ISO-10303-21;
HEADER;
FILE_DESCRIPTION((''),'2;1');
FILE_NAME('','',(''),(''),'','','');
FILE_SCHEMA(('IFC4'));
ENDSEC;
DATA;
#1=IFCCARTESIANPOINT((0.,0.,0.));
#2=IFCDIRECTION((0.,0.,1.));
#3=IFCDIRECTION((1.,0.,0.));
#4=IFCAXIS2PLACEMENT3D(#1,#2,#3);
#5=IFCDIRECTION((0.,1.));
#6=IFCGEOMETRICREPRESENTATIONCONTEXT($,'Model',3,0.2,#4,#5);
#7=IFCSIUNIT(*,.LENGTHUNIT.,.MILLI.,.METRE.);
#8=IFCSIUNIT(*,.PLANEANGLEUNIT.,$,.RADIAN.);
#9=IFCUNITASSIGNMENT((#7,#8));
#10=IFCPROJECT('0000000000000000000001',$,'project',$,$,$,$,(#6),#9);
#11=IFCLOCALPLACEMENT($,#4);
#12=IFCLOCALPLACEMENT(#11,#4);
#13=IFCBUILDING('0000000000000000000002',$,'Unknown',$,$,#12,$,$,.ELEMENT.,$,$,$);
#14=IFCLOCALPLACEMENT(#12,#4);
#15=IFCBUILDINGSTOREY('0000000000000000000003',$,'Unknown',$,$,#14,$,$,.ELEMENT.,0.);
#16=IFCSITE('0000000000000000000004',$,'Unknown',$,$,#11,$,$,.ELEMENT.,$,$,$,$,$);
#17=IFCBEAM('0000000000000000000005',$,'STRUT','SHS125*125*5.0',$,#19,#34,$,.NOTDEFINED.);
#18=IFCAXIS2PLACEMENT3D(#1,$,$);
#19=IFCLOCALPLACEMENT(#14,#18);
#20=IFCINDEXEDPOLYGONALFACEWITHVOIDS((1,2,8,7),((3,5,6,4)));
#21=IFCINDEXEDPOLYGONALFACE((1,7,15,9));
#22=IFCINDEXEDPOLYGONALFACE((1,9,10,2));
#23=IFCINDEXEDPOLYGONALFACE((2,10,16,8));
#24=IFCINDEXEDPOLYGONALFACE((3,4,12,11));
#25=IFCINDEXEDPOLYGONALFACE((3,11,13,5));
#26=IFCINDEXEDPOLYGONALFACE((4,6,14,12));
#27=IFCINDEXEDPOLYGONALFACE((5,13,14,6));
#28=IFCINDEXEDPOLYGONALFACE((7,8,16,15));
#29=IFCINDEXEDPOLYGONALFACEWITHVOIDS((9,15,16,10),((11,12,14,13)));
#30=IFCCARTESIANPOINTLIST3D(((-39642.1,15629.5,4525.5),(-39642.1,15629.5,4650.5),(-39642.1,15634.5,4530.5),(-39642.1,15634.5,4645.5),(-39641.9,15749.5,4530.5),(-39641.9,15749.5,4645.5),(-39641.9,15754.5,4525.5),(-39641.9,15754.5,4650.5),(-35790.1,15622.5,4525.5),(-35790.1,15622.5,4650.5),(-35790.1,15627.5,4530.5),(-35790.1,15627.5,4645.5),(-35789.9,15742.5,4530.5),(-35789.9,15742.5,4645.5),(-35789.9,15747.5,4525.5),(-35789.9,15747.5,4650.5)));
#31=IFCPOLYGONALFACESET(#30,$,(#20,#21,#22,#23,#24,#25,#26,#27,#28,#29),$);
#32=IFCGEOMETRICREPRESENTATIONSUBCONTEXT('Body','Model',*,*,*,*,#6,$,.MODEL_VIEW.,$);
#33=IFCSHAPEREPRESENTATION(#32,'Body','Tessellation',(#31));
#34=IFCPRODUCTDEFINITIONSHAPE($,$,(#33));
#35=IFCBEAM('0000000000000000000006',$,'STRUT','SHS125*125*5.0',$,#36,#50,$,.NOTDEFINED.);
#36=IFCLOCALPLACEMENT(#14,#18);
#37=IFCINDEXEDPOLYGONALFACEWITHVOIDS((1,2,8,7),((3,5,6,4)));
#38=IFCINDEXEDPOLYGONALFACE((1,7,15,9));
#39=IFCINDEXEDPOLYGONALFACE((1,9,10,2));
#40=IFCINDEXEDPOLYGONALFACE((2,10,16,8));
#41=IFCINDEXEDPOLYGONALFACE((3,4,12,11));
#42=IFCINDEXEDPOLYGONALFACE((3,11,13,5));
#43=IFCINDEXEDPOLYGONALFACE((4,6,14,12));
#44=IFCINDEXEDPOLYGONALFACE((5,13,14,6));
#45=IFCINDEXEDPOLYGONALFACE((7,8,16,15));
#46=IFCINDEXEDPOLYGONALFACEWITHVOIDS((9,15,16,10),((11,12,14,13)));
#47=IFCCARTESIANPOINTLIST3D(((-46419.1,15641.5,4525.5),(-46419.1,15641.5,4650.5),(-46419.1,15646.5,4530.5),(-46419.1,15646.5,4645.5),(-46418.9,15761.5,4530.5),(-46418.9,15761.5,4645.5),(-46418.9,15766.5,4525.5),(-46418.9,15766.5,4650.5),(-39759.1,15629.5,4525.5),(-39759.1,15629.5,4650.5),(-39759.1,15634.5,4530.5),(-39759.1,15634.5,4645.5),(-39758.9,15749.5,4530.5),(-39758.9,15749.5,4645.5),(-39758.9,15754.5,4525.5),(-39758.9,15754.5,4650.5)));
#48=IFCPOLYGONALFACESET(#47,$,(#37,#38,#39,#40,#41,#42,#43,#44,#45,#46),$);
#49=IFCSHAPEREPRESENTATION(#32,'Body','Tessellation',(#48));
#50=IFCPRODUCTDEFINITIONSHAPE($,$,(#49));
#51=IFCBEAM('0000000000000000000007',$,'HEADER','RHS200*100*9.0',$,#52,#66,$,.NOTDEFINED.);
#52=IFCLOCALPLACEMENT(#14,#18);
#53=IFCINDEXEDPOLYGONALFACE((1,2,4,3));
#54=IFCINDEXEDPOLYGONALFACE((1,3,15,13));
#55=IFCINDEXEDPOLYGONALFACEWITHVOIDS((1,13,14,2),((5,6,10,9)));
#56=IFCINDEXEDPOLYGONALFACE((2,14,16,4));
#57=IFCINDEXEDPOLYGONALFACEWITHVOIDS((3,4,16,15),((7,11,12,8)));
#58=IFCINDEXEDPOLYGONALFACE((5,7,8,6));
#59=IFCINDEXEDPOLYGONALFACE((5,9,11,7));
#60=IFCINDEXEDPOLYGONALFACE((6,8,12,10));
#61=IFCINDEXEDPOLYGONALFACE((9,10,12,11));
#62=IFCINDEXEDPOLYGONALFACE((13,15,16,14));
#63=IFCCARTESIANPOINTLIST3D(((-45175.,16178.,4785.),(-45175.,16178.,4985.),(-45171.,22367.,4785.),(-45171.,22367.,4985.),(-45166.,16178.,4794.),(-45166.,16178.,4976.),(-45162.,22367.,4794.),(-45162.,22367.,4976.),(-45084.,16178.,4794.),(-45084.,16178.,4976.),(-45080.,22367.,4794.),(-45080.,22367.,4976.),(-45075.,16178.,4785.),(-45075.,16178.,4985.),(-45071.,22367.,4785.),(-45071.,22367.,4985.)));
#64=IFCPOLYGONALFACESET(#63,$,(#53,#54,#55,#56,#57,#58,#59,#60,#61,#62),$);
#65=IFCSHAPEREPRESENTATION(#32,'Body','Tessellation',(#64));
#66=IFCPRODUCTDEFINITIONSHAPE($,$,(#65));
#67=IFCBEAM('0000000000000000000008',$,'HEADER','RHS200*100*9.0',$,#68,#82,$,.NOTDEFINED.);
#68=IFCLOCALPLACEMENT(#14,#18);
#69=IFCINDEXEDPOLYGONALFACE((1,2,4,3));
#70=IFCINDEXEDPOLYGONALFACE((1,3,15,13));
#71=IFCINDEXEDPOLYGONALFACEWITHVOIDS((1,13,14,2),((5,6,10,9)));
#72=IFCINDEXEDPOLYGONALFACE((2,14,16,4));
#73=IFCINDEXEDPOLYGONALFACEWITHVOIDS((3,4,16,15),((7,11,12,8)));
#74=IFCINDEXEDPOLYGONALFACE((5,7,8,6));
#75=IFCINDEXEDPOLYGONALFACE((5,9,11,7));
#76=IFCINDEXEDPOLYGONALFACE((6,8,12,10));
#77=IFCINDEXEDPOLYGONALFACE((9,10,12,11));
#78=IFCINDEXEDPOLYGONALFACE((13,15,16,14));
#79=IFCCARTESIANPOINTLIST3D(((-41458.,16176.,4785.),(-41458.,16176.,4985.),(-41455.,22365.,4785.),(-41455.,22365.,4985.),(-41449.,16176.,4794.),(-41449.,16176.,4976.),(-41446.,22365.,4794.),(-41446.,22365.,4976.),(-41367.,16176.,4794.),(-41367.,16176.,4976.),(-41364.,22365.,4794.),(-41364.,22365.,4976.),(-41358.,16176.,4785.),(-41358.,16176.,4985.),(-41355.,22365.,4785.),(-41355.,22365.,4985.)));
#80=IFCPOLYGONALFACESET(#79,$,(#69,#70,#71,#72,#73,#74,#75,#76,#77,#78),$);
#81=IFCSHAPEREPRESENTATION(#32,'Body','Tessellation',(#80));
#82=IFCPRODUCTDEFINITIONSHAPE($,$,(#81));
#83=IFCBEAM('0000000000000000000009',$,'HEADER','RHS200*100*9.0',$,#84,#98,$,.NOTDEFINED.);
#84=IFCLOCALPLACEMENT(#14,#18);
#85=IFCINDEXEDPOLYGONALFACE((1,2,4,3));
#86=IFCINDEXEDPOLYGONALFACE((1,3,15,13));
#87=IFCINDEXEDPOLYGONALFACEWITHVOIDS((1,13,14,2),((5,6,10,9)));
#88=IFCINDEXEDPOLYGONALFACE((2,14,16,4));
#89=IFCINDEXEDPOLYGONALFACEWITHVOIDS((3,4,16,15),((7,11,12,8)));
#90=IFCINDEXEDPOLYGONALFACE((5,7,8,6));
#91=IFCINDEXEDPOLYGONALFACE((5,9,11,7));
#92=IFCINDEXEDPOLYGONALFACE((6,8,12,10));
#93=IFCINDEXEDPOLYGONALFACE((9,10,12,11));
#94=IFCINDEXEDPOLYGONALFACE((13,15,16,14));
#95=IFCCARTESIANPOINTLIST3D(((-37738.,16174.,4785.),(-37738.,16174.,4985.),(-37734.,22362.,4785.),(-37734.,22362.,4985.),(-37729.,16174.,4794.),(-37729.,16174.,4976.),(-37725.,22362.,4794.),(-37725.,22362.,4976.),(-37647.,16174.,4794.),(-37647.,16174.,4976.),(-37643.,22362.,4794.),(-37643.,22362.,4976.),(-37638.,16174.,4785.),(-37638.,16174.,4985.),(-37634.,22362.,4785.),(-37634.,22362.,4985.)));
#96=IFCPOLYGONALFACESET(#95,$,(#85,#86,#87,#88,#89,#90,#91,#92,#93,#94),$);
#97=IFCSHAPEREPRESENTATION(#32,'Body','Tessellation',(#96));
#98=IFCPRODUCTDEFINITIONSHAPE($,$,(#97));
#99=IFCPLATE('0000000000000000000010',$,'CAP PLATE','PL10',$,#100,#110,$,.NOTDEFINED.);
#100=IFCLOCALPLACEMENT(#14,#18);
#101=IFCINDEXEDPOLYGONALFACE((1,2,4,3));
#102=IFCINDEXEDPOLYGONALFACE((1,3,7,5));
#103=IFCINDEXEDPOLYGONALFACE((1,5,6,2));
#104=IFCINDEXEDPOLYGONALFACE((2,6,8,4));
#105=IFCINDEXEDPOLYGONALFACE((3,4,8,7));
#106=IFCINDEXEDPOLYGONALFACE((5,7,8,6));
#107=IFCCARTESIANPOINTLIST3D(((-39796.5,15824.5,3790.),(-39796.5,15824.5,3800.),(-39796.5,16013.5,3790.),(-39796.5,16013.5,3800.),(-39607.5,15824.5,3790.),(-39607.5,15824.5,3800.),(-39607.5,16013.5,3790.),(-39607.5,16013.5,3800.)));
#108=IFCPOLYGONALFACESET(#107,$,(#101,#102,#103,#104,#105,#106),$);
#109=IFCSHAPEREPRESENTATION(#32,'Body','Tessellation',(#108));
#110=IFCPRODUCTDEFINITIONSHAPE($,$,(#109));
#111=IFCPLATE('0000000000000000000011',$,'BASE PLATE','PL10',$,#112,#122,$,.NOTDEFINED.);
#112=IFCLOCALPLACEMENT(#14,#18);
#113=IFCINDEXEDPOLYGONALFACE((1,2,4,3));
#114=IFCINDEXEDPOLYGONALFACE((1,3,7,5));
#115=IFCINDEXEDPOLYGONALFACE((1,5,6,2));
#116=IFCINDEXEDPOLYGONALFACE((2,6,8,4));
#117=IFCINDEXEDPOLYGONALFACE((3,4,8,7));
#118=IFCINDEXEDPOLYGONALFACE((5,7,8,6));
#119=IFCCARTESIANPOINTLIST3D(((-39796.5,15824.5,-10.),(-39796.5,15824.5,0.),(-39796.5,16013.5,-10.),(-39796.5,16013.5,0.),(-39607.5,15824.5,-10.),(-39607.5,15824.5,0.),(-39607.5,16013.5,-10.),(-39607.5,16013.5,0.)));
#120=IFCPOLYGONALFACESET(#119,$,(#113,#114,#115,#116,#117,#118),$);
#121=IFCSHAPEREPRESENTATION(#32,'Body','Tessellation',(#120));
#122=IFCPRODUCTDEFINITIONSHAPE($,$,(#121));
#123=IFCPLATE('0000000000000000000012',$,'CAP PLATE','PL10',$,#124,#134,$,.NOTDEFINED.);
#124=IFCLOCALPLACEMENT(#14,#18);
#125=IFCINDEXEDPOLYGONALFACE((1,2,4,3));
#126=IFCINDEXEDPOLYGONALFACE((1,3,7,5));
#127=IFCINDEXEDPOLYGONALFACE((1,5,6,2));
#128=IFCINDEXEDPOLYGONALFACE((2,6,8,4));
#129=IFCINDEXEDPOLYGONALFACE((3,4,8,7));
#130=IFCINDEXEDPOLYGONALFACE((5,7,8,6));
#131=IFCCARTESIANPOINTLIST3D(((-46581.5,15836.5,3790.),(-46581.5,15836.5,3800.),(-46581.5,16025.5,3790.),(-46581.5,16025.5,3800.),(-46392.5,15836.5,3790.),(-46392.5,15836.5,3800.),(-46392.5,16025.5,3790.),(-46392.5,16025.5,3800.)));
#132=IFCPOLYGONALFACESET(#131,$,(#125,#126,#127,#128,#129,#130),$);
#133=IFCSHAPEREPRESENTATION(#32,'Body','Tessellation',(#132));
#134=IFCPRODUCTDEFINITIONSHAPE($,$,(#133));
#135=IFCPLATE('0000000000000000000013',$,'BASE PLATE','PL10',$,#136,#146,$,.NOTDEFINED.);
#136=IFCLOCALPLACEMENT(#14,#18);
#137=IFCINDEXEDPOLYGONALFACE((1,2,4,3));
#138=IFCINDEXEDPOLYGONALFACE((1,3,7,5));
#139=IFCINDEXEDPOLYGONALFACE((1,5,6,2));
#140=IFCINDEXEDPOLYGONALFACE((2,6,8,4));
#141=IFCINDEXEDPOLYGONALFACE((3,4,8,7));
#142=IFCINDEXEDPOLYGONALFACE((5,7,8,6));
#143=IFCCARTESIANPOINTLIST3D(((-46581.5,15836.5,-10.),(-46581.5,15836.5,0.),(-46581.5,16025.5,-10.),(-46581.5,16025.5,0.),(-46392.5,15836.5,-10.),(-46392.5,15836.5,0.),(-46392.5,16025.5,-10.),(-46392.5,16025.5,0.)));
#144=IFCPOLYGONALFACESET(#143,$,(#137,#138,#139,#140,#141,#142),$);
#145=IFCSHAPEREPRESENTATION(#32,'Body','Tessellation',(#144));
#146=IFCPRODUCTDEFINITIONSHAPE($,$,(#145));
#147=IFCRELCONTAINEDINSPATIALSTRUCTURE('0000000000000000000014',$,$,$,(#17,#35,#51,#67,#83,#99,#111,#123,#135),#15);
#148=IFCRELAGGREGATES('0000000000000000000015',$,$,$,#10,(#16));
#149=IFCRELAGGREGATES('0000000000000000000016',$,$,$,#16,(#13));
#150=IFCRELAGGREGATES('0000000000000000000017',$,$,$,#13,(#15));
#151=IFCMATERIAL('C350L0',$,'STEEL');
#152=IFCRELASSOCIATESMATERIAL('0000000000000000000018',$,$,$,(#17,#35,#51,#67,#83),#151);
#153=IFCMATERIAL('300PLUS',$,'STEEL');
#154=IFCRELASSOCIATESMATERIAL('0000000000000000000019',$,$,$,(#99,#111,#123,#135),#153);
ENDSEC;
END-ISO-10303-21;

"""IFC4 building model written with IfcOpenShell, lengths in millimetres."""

from ifc_helpers import new_model, si_unit, direction, frame, origin_with_axes, place, context, subcontext, project, spatial, line, indexed_curve, outline, extrude, material, element, save


model = new_model("IFC4")

# Units and contexts
model_context = context("Model", 3, precision=0.2, world=origin_with_axes(), true_north=direction((0.0, 1.0)))
body_context = subcontext(model_context, "Body", "Model", "MODEL_VIEW")
ifc_project = project(units=[si_unit("LENGTHUNIT", "METRE", prefix="MILLI"), si_unit("PLANEANGLEUNIT", "RADIAN")], contexts=[model_context])

# Site, building, storey
site_placement = place(None, origin_with_axes())
site = spatial("IfcSite", under=ifc_project, at=site_placement, Name="Unknown", CompositionType="ELEMENT")
building_placement = place(site_placement, origin_with_axes())
building = spatial("IfcBuilding", under=site, at=building_placement, Name="Unknown", CompositionType="ELEMENT")
storey_placement = place(building_placement, origin_with_axes())
storey = spatial("IfcBuildingStorey", under=building, at=storey_placement, Name="Unknown", CompositionType="ELEMENT", Elevation=0.0)

# Shared definitions
ifc_material_1 = material(Name="C350L0", Category="STEEL")

# Beams
beam_1_placement = place(storey_placement, frame((-39642.0, 15692.0, 4588.0), z_axis=(0.0, 0.0, 1.0), x_axis=(0.999998, -0.001817, 0.0)))
element("IfcBeam", 1, at=beam_1_placement, inside=storey, material=ifc_material_1, Name="STRUT", Description="SHS125*125*5.0", PredefinedType="NOTDEFINED", context=body_context, shape_type="SolidModel", body=[
    extrude(outline(indexed_curve([(-62.5, -62.5), (62.5, -62.5), (62.5, 62.5), (-62.5, 62.5)], segments=[line(1, 2, 3, 4, 1)]), holes=[indexed_curve([(-57.5, -57.5), (-57.5, 57.5), (57.5, 57.5), (57.5, -57.5)], segments=[line(1, 2, 3, 4, 1)])]), frame((0.0, 0.0, 0.0), z_axis=(-1.0, 0.0, 0.0), x_axis=(0.0, 0.0, 1.0)), (0.0, 0.0, -1.0), 3852.0),
])
beam_2_placement = place(storey_placement, frame((-46419.0, 15704.0, 4588.0), z_axis=(0.0, 0.0, 1.0), x_axis=(0.999998, -0.001802, 0.0)))
element("IfcBeam", 2, at=beam_2_placement, inside=storey, material=ifc_material_1, Name="STRUT", Description="SHS125*125*5.0", PredefinedType="NOTDEFINED", context=body_context, shape_type="SolidModel", body=[
    extrude(outline(indexed_curve([(-62.5, -62.5), (62.5, -62.5), (62.5, 62.5), (-62.5, 62.5)], segments=[line(1, 2, 3, 4, 1)]), holes=[indexed_curve([(-57.5, -57.5), (-57.5, 57.5), (57.5, 57.5), (57.5, -57.5)], segments=[line(1, 2, 3, 4, 1)])]), frame((0.0, 0.0, 0.0), z_axis=(-1.0, 0.0, 0.0), x_axis=(0.0, 0.0, 1.0)), (0.0, 0.0, -1.0), 6660.0),
])
beam_3_placement = place(storey_placement, frame((-45125.0, 16178.0, 4885.0), z_axis=(1.0, -0.000646, 0.0), x_axis=(0.000646, 1.0, 0.0)))
element("IfcBeam", 3, at=beam_3_placement, inside=storey, material=ifc_material_1, Name="HEADER", Description="RHS200*100*9.0", PredefinedType="NOTDEFINED", context=body_context, shape_type="SolidModel", body=[
    extrude(outline(indexed_curve([(-50.0, -100.0), (50.0, -100.0), (50.0, 100.0), (-50.0, 100.0)], segments=[line(1, 2, 3, 4, 1)]), holes=[indexed_curve([(-41.0, -91.0), (-41.0, 91.0), (41.0, 91.0), (41.0, -91.0)], segments=[line(1, 2, 3, 4, 1)])]), frame((0.0, 0.0, 0.0), z_axis=(-1.0, 0.0, 0.0), x_axis=(0.0, 0.0, 1.0)), (0.0, 0.0, -1.0), 6189.0),
])
beam_4_placement = place(storey_placement, frame((-41408.0, 16176.0, 4885.0), z_axis=(1.0, -0.000485, 0.0), x_axis=(0.000485, 1.0, 0.0)))
element("IfcBeam", 4, at=beam_4_placement, inside=storey, material=ifc_material_1, Name="HEADER", Description="RHS200*100*9.0", PredefinedType="NOTDEFINED", context=body_context, shape_type="SolidModel", body=[
    extrude(outline(indexed_curve([(-50.0, -100.0), (50.0, -100.0), (50.0, 100.0), (-50.0, 100.0)], segments=[line(1, 2, 3, 4, 1)]), holes=[indexed_curve([(-41.0, -91.0), (-41.0, 91.0), (41.0, 91.0), (41.0, -91.0)], segments=[line(1, 2, 3, 4, 1)])]), frame((0.0, 0.0, 0.0), z_axis=(-1.0, 0.0, 0.0), x_axis=(0.0, 0.0, 1.0)), (0.0, 0.0, -1.0), 6189.0),
])
beam_5_placement = place(storey_placement, frame((-37688.0, 16174.0, 4885.0), z_axis=(1.0, -0.000646, 0.0), x_axis=(0.000646, 1.0, 0.0)))
element("IfcBeam", 5, at=beam_5_placement, inside=storey, material=ifc_material_1, Name="HEADER", Description="RHS200*100*9.0", PredefinedType="NOTDEFINED", context=body_context, shape_type="SolidModel", body=[
    extrude(outline(indexed_curve([(-50.0, -100.0), (50.0, -100.0), (50.0, 100.0), (-50.0, 100.0)], segments=[line(1, 2, 3, 4, 1)]), holes=[indexed_curve([(-41.0, -91.0), (-41.0, 91.0), (41.0, 91.0), (41.0, -91.0)], segments=[line(1, 2, 3, 4, 1)])]), frame((0.0, 0.0, 0.0), z_axis=(-1.0, 0.0, 0.0), x_axis=(0.0, 0.0, 1.0)), (0.0, 0.0, -1.0), 6188.0),
])

# Plates
ifc_material_2 = material(Name="300PLUS", Category="STEEL")
for number, where, z_axis, x_axis, name in (
    (6, (-39796.5, 15824.5, 3795.0), (0.0, 0.0, 1.0), (1.0, 0.0, 0.0), "CAP PLATE"),
    (7, (-39796.5, 15824.5, -5.0), (0.0, 0.0, 1.0), (1.0, 0.0, 0.0), "BASE PLATE"),
    (8, (-46581.5, 15836.5, 3795.0), (0.0, 0.0, 1.0), (1.0, 0.0, 0.0), "CAP PLATE"),
    (9, (-46581.5, 15836.5, -5.0), (0.0, 0.0, 1.0), (1.0, 0.0, 0.0), "BASE PLATE"),
):
    element("IfcPlate", number, at=place(storey_placement, frame(where, z_axis=z_axis, x_axis=x_axis)), inside=storey, material=ifc_material_2, Name=name, Description="PL10", PredefinedType="NOTDEFINED", context=body_context, shape_type="SolidModel", body=[
        extrude(outline(indexed_curve([(0.0, 0.0), (189.0, 0.0), (189.0, 189.0), (0.0, 189.0)], segments=[line(1, 2, 3, 4, 1)])), frame((0.0, 0.0, 5.0), z_axis=(0.0, 0.0, 1.0), x_axis=(1.0, 0.0, 0.0)), (0.0, 0.0, -1.0), 10.0),
    ])

save(model, "model.ifc")
